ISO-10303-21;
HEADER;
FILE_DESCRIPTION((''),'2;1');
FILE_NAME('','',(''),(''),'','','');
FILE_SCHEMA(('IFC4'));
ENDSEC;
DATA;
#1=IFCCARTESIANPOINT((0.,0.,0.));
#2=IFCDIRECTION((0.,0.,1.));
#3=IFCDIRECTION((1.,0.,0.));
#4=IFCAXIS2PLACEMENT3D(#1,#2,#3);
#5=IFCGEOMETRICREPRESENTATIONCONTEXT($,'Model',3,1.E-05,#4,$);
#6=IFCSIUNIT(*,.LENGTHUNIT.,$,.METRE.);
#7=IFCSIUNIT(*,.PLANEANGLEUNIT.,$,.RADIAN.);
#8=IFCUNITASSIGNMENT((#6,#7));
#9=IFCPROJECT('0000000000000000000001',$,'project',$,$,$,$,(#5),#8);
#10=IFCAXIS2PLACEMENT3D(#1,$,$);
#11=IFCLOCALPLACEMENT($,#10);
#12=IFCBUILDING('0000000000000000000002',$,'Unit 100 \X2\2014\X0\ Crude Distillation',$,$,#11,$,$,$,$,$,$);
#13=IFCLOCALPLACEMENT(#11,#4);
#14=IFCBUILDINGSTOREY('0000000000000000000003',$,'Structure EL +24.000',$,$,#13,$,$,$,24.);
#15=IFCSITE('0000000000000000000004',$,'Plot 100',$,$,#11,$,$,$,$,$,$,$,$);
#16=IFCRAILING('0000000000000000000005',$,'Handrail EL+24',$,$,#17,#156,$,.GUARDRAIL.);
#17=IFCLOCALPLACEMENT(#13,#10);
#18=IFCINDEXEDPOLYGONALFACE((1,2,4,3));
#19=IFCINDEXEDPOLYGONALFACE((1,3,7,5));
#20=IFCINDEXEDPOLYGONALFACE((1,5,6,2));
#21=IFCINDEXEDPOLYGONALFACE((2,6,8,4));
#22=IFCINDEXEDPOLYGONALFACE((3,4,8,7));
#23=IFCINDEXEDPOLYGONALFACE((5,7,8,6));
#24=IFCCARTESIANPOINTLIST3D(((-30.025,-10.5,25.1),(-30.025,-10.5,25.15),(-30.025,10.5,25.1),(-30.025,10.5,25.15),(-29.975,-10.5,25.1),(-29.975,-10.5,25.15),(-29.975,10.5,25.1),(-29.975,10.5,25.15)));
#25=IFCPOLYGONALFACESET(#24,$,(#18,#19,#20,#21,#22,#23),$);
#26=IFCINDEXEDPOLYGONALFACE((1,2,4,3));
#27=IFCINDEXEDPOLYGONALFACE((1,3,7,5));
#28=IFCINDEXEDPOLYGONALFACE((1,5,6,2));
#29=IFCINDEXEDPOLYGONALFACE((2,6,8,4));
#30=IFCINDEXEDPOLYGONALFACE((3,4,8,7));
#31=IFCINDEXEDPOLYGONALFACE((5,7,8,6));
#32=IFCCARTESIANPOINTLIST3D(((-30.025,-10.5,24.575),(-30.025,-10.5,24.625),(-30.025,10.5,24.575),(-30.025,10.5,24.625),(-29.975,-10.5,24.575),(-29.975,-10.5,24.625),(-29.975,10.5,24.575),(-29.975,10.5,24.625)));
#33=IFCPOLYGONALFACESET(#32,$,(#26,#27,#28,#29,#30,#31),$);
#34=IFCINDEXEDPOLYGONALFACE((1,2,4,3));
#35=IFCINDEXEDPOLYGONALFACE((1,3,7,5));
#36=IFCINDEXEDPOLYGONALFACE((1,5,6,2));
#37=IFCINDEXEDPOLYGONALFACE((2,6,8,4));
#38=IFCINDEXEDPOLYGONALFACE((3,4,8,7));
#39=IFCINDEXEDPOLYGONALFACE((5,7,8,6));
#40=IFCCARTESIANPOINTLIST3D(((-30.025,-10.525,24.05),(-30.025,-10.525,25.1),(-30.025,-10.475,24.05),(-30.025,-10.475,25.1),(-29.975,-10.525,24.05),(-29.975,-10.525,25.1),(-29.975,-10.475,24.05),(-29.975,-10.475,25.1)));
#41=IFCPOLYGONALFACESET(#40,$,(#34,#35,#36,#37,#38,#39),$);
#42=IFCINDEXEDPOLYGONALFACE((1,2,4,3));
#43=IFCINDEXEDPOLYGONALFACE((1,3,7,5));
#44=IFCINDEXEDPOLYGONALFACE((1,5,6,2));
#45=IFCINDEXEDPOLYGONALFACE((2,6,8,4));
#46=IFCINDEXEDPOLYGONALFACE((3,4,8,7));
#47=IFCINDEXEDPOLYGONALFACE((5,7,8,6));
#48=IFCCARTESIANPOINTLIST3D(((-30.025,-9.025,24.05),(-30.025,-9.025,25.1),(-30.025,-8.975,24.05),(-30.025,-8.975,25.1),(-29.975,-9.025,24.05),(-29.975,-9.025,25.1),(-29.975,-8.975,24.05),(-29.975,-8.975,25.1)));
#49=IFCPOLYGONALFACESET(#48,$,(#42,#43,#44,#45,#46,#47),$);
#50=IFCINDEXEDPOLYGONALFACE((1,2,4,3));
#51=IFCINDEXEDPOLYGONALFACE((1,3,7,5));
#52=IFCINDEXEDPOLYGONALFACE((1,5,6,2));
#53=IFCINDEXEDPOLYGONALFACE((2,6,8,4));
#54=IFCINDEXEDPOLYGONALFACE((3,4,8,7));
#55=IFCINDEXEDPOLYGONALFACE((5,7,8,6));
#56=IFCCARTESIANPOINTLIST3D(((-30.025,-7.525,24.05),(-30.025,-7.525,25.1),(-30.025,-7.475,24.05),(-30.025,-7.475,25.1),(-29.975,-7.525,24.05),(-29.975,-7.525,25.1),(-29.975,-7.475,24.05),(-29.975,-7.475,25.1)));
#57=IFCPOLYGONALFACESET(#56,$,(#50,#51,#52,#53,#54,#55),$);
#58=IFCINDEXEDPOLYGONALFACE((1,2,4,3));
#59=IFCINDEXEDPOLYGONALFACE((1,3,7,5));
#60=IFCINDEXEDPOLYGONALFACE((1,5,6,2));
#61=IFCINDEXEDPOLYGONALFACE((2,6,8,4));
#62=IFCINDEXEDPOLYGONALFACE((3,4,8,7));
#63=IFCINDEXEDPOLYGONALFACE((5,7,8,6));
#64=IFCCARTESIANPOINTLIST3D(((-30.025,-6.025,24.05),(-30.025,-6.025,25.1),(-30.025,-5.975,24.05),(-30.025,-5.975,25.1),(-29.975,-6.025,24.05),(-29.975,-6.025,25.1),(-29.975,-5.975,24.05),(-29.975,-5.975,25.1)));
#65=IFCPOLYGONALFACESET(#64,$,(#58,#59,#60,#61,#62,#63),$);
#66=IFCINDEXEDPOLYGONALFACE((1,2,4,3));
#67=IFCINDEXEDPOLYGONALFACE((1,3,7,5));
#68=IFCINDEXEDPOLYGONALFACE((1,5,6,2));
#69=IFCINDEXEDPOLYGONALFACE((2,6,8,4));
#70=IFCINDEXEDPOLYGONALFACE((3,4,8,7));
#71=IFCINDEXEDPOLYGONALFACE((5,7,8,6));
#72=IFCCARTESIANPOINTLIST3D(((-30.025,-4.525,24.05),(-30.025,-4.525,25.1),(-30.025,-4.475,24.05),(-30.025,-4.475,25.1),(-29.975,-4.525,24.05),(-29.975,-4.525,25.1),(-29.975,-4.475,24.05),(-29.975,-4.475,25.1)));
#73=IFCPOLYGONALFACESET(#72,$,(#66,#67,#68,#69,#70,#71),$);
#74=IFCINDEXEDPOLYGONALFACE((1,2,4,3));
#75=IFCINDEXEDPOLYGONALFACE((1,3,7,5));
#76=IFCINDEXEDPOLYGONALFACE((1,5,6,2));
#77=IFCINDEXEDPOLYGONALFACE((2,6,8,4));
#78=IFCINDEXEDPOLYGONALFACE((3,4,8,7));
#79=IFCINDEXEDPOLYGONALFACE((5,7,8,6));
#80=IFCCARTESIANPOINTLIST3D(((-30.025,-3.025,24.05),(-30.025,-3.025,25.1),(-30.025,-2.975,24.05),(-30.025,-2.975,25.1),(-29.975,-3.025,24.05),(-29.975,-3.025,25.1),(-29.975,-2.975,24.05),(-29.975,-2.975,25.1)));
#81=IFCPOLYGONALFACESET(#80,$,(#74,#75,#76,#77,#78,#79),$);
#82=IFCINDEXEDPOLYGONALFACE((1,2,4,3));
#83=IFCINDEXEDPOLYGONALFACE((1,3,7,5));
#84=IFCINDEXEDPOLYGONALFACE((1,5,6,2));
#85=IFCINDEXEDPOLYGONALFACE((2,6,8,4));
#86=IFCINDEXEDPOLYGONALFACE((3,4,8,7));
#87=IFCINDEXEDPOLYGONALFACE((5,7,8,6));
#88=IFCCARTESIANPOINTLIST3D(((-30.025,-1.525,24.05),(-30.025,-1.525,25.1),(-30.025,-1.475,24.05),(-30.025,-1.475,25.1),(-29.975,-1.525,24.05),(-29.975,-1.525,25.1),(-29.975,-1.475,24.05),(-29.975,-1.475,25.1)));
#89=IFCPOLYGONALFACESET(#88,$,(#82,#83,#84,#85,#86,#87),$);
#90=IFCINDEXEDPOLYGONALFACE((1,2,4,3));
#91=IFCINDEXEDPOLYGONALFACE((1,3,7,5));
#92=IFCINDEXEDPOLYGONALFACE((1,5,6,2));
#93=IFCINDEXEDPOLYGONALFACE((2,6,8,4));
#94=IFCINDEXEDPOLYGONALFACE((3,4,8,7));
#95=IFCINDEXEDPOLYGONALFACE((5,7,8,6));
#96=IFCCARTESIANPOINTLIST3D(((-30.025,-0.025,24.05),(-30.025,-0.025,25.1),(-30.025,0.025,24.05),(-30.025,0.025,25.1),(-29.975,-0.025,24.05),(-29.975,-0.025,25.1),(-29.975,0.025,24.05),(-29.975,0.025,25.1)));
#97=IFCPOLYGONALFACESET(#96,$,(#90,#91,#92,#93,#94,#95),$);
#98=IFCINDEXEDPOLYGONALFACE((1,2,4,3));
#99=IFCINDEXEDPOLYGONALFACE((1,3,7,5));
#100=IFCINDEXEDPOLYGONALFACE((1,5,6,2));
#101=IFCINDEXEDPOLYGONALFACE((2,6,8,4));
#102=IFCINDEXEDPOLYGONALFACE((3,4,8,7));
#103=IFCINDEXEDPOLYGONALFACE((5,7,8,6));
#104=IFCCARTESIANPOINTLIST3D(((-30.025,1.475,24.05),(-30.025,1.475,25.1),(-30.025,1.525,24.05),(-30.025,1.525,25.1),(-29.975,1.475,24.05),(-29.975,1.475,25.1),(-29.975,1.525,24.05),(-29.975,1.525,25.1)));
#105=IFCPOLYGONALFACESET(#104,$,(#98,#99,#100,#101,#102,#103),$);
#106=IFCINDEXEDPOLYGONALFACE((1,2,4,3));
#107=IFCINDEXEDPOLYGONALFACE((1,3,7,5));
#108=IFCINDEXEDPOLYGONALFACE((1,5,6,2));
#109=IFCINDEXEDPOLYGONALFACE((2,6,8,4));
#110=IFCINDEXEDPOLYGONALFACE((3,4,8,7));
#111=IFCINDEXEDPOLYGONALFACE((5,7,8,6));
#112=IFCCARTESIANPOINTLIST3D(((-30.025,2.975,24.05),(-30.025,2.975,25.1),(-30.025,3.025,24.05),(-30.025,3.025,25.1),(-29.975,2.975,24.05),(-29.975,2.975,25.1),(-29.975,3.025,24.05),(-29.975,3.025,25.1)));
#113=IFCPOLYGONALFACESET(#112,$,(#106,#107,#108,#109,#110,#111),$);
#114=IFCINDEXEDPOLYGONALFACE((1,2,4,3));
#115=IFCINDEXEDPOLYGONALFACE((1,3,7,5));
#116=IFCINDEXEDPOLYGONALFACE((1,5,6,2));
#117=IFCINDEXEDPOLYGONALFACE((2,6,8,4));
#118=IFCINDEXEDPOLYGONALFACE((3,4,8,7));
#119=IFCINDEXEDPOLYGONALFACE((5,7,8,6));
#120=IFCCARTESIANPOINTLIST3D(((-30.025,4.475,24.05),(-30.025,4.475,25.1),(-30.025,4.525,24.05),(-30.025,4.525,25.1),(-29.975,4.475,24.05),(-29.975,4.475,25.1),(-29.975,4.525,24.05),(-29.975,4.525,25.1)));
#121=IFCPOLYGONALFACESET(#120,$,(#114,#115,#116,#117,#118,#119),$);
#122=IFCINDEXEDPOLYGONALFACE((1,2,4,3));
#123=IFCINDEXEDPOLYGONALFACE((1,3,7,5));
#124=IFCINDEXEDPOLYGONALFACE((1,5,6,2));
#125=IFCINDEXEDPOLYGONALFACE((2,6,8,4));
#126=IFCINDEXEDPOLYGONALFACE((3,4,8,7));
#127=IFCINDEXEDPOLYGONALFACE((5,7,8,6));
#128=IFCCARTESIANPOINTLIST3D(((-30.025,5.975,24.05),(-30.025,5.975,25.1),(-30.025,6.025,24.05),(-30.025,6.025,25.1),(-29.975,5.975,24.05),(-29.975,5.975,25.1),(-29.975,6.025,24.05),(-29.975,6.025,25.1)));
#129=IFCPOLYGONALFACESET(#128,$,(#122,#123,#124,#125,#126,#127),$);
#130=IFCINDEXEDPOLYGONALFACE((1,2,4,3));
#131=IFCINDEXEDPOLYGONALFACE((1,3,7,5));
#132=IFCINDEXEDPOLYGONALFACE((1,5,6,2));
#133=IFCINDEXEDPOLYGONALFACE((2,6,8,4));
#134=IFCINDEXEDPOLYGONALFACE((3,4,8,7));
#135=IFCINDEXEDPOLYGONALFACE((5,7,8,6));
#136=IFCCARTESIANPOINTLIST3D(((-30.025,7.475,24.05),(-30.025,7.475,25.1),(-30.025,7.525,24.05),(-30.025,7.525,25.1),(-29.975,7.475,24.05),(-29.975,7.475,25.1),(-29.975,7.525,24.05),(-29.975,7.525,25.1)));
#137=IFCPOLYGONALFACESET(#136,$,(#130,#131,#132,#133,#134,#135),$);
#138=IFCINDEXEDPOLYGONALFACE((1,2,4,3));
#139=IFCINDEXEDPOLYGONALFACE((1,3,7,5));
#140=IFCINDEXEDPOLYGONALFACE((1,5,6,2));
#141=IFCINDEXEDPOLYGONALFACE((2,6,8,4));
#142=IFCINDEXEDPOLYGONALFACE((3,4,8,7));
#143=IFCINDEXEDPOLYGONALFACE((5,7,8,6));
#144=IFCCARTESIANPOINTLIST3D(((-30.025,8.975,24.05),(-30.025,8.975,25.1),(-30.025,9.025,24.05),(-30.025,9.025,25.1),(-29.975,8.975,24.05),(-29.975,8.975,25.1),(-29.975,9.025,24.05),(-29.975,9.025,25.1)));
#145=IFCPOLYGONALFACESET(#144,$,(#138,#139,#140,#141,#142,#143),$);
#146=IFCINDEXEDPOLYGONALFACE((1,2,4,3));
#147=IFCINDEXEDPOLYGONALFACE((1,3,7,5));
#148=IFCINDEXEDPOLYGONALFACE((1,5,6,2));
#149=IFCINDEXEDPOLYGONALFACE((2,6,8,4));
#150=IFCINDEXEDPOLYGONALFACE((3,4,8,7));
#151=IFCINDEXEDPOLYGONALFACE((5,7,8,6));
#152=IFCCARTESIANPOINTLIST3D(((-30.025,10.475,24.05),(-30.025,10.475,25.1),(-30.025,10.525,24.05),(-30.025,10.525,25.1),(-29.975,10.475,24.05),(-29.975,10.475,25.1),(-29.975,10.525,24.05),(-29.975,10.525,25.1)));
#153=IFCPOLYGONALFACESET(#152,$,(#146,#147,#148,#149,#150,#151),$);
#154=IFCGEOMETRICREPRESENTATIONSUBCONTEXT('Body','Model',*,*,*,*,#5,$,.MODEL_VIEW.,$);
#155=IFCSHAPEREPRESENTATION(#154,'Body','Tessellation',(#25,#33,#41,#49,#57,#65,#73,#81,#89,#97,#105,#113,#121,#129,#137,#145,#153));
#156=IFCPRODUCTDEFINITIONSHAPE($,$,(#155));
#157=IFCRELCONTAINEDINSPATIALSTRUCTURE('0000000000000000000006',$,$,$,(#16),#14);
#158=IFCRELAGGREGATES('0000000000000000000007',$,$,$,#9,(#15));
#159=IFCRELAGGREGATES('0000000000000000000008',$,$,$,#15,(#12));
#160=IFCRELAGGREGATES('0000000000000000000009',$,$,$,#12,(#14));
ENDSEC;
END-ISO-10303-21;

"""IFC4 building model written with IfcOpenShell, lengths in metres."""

from ifc_helpers import new_model, si_unit, frame, origin, origin_with_axes, origin_2d, place, context, subcontext, project, spatial, rectangle, extrude, element, save


model = new_model("IFC4")

# Units and contexts
model_context = context("Model", 3, precision=1e-05, world=origin_with_axes())
body_context = subcontext(model_context, "Body", "Model", "MODEL_VIEW")
ifc_project = project(units=[si_unit("LENGTHUNIT", "METRE"), si_unit("PLANEANGLEUNIT", "RADIAN")], contexts=[model_context])

# Site, building, storey
placement = place(None, origin())
site = spatial("IfcSite", under=ifc_project, at=placement, Name="Plot 100")
building = spatial("IfcBuilding", under=site, at=placement, Name="Unit 100 — Crude Distillation")
storey_placement = place(placement, origin_with_axes())
storey = spatial("IfcBuildingStorey", under=building, at=storey_placement, Name="Structure EL +24.000", Elevation=24.0)

# Railing
railing_1_placement = place(storey_placement, origin_with_axes())
element("IfcRailing", 1, at=railing_1_placement, inside=storey, Name="Handrail EL+24", PredefinedType="GUARDRAIL", context=body_context, shape_type="SweptSolid", body=[
    extrude(rectangle(XDim=0.05, YDim=0.05, at=origin_2d()), frame((-30.0, -10.5, 25.125), z_axis=(0.0, 1.0, 0.0), x_axis=(-1.0, 0.0, 0.0)), (0.0, 0.0, 1.0), 21.0),
    extrude(rectangle(XDim=0.05, YDim=0.05, at=origin_2d()), frame((-30.0, -10.5, 24.6), z_axis=(0.0, 1.0, 0.0), x_axis=(-1.0, 0.0, 0.0)), (0.0, 0.0, 1.0), 21.0),
    extrude(rectangle(XDim=0.05, YDim=0.05, at=origin_2d()), frame((-30.0, -10.5, 24.05), z_axis=(0.0, 0.0, 1.0), x_axis=(1.0, 0.0, 0.0)), (0.0, 0.0, 1.0), 1.05),
    extrude(rectangle(XDim=0.05, YDim=0.05, at=origin_2d()), frame((-30.0, -9.0, 24.05), z_axis=(0.0, 0.0, 1.0), x_axis=(1.0, 0.0, 0.0)), (0.0, 0.0, 1.0), 1.05),
    extrude(rectangle(XDim=0.05, YDim=0.05, at=origin_2d()), frame((-30.0, -7.5, 24.05), z_axis=(0.0, 0.0, 1.0), x_axis=(1.0, 0.0, 0.0)), (0.0, 0.0, 1.0), 1.05),
    extrude(rectangle(XDim=0.05, YDim=0.05, at=origin_2d()), frame((-30.0, -6.0, 24.05), z_axis=(0.0, 0.0, 1.0), x_axis=(1.0, 0.0, 0.0)), (0.0, 0.0, 1.0), 1.05),
    extrude(rectangle(XDim=0.05, YDim=0.05, at=origin_2d()), frame((-30.0, -4.5, 24.05), z_axis=(0.0, 0.0, 1.0), x_axis=(1.0, 0.0, 0.0)), (0.0, 0.0, 1.0), 1.05),
    extrude(rectangle(XDim=0.05, YDim=0.05, at=origin_2d()), frame((-30.0, -3.0, 24.05), z_axis=(0.0, 0.0, 1.0), x_axis=(1.0, 0.0, 0.0)), (0.0, 0.0, 1.0), 1.05),
    extrude(rectangle(XDim=0.05, YDim=0.05, at=origin_2d()), frame((-30.0, -1.5, 24.05), z_axis=(0.0, 0.0, 1.0), x_axis=(1.0, 0.0, 0.0)), (0.0, 0.0, 1.0), 1.05),
    extrude(rectangle(XDim=0.05, YDim=0.05, at=origin_2d()), frame((-30.0, 0.0, 24.05), z_axis=(0.0, 0.0, 1.0), x_axis=(1.0, 0.0, 0.0)), (0.0, 0.0, 1.0), 1.05),
    extrude(rectangle(XDim=0.05, YDim=0.05, at=origin_2d()), frame((-30.0, 1.5, 24.05), z_axis=(0.0, 0.0, 1.0), x_axis=(1.0, 0.0, 0.0)), (0.0, 0.0, 1.0), 1.05),
    extrude(rectangle(XDim=0.05, YDim=0.05, at=origin_2d()), frame((-30.0, 3.0, 24.05), z_axis=(0.0, 0.0, 1.0), x_axis=(1.0, 0.0, 0.0)), (0.0, 0.0, 1.0), 1.05),
    extrude(rectangle(XDim=0.05, YDim=0.05, at=origin_2d()), frame((-30.0, 4.5, 24.05), z_axis=(0.0, 0.0, 1.0), x_axis=(1.0, 0.0, 0.0)), (0.0, 0.0, 1.0), 1.05),
    extrude(rectangle(XDim=0.05, YDim=0.05, at=origin_2d()), frame((-30.0, 6.0, 24.05), z_axis=(0.0, 0.0, 1.0), x_axis=(1.0, 0.0, 0.0)), (0.0, 0.0, 1.0), 1.05),
    extrude(rectangle(XDim=0.05, YDim=0.05, at=origin_2d()), frame((-30.0, 7.5, 24.05), z_axis=(0.0, 0.0, 1.0), x_axis=(1.0, 0.0, 0.0)), (0.0, 0.0, 1.0), 1.05),
    extrude(rectangle(XDim=0.05, YDim=0.05, at=origin_2d()), frame((-30.0, 9.0, 24.05), z_axis=(0.0, 0.0, 1.0), x_axis=(1.0, 0.0, 0.0)), (0.0, 0.0, 1.0), 1.05),
    extrude(rectangle(XDim=0.05, YDim=0.05, at=origin_2d()), frame((-30.0, 10.5, 24.05), z_axis=(0.0, 0.0, 1.0), x_axis=(1.0, 0.0, 0.0)), (0.0, 0.0, 1.0), 1.05),
])

save(model, "model.ifc")
